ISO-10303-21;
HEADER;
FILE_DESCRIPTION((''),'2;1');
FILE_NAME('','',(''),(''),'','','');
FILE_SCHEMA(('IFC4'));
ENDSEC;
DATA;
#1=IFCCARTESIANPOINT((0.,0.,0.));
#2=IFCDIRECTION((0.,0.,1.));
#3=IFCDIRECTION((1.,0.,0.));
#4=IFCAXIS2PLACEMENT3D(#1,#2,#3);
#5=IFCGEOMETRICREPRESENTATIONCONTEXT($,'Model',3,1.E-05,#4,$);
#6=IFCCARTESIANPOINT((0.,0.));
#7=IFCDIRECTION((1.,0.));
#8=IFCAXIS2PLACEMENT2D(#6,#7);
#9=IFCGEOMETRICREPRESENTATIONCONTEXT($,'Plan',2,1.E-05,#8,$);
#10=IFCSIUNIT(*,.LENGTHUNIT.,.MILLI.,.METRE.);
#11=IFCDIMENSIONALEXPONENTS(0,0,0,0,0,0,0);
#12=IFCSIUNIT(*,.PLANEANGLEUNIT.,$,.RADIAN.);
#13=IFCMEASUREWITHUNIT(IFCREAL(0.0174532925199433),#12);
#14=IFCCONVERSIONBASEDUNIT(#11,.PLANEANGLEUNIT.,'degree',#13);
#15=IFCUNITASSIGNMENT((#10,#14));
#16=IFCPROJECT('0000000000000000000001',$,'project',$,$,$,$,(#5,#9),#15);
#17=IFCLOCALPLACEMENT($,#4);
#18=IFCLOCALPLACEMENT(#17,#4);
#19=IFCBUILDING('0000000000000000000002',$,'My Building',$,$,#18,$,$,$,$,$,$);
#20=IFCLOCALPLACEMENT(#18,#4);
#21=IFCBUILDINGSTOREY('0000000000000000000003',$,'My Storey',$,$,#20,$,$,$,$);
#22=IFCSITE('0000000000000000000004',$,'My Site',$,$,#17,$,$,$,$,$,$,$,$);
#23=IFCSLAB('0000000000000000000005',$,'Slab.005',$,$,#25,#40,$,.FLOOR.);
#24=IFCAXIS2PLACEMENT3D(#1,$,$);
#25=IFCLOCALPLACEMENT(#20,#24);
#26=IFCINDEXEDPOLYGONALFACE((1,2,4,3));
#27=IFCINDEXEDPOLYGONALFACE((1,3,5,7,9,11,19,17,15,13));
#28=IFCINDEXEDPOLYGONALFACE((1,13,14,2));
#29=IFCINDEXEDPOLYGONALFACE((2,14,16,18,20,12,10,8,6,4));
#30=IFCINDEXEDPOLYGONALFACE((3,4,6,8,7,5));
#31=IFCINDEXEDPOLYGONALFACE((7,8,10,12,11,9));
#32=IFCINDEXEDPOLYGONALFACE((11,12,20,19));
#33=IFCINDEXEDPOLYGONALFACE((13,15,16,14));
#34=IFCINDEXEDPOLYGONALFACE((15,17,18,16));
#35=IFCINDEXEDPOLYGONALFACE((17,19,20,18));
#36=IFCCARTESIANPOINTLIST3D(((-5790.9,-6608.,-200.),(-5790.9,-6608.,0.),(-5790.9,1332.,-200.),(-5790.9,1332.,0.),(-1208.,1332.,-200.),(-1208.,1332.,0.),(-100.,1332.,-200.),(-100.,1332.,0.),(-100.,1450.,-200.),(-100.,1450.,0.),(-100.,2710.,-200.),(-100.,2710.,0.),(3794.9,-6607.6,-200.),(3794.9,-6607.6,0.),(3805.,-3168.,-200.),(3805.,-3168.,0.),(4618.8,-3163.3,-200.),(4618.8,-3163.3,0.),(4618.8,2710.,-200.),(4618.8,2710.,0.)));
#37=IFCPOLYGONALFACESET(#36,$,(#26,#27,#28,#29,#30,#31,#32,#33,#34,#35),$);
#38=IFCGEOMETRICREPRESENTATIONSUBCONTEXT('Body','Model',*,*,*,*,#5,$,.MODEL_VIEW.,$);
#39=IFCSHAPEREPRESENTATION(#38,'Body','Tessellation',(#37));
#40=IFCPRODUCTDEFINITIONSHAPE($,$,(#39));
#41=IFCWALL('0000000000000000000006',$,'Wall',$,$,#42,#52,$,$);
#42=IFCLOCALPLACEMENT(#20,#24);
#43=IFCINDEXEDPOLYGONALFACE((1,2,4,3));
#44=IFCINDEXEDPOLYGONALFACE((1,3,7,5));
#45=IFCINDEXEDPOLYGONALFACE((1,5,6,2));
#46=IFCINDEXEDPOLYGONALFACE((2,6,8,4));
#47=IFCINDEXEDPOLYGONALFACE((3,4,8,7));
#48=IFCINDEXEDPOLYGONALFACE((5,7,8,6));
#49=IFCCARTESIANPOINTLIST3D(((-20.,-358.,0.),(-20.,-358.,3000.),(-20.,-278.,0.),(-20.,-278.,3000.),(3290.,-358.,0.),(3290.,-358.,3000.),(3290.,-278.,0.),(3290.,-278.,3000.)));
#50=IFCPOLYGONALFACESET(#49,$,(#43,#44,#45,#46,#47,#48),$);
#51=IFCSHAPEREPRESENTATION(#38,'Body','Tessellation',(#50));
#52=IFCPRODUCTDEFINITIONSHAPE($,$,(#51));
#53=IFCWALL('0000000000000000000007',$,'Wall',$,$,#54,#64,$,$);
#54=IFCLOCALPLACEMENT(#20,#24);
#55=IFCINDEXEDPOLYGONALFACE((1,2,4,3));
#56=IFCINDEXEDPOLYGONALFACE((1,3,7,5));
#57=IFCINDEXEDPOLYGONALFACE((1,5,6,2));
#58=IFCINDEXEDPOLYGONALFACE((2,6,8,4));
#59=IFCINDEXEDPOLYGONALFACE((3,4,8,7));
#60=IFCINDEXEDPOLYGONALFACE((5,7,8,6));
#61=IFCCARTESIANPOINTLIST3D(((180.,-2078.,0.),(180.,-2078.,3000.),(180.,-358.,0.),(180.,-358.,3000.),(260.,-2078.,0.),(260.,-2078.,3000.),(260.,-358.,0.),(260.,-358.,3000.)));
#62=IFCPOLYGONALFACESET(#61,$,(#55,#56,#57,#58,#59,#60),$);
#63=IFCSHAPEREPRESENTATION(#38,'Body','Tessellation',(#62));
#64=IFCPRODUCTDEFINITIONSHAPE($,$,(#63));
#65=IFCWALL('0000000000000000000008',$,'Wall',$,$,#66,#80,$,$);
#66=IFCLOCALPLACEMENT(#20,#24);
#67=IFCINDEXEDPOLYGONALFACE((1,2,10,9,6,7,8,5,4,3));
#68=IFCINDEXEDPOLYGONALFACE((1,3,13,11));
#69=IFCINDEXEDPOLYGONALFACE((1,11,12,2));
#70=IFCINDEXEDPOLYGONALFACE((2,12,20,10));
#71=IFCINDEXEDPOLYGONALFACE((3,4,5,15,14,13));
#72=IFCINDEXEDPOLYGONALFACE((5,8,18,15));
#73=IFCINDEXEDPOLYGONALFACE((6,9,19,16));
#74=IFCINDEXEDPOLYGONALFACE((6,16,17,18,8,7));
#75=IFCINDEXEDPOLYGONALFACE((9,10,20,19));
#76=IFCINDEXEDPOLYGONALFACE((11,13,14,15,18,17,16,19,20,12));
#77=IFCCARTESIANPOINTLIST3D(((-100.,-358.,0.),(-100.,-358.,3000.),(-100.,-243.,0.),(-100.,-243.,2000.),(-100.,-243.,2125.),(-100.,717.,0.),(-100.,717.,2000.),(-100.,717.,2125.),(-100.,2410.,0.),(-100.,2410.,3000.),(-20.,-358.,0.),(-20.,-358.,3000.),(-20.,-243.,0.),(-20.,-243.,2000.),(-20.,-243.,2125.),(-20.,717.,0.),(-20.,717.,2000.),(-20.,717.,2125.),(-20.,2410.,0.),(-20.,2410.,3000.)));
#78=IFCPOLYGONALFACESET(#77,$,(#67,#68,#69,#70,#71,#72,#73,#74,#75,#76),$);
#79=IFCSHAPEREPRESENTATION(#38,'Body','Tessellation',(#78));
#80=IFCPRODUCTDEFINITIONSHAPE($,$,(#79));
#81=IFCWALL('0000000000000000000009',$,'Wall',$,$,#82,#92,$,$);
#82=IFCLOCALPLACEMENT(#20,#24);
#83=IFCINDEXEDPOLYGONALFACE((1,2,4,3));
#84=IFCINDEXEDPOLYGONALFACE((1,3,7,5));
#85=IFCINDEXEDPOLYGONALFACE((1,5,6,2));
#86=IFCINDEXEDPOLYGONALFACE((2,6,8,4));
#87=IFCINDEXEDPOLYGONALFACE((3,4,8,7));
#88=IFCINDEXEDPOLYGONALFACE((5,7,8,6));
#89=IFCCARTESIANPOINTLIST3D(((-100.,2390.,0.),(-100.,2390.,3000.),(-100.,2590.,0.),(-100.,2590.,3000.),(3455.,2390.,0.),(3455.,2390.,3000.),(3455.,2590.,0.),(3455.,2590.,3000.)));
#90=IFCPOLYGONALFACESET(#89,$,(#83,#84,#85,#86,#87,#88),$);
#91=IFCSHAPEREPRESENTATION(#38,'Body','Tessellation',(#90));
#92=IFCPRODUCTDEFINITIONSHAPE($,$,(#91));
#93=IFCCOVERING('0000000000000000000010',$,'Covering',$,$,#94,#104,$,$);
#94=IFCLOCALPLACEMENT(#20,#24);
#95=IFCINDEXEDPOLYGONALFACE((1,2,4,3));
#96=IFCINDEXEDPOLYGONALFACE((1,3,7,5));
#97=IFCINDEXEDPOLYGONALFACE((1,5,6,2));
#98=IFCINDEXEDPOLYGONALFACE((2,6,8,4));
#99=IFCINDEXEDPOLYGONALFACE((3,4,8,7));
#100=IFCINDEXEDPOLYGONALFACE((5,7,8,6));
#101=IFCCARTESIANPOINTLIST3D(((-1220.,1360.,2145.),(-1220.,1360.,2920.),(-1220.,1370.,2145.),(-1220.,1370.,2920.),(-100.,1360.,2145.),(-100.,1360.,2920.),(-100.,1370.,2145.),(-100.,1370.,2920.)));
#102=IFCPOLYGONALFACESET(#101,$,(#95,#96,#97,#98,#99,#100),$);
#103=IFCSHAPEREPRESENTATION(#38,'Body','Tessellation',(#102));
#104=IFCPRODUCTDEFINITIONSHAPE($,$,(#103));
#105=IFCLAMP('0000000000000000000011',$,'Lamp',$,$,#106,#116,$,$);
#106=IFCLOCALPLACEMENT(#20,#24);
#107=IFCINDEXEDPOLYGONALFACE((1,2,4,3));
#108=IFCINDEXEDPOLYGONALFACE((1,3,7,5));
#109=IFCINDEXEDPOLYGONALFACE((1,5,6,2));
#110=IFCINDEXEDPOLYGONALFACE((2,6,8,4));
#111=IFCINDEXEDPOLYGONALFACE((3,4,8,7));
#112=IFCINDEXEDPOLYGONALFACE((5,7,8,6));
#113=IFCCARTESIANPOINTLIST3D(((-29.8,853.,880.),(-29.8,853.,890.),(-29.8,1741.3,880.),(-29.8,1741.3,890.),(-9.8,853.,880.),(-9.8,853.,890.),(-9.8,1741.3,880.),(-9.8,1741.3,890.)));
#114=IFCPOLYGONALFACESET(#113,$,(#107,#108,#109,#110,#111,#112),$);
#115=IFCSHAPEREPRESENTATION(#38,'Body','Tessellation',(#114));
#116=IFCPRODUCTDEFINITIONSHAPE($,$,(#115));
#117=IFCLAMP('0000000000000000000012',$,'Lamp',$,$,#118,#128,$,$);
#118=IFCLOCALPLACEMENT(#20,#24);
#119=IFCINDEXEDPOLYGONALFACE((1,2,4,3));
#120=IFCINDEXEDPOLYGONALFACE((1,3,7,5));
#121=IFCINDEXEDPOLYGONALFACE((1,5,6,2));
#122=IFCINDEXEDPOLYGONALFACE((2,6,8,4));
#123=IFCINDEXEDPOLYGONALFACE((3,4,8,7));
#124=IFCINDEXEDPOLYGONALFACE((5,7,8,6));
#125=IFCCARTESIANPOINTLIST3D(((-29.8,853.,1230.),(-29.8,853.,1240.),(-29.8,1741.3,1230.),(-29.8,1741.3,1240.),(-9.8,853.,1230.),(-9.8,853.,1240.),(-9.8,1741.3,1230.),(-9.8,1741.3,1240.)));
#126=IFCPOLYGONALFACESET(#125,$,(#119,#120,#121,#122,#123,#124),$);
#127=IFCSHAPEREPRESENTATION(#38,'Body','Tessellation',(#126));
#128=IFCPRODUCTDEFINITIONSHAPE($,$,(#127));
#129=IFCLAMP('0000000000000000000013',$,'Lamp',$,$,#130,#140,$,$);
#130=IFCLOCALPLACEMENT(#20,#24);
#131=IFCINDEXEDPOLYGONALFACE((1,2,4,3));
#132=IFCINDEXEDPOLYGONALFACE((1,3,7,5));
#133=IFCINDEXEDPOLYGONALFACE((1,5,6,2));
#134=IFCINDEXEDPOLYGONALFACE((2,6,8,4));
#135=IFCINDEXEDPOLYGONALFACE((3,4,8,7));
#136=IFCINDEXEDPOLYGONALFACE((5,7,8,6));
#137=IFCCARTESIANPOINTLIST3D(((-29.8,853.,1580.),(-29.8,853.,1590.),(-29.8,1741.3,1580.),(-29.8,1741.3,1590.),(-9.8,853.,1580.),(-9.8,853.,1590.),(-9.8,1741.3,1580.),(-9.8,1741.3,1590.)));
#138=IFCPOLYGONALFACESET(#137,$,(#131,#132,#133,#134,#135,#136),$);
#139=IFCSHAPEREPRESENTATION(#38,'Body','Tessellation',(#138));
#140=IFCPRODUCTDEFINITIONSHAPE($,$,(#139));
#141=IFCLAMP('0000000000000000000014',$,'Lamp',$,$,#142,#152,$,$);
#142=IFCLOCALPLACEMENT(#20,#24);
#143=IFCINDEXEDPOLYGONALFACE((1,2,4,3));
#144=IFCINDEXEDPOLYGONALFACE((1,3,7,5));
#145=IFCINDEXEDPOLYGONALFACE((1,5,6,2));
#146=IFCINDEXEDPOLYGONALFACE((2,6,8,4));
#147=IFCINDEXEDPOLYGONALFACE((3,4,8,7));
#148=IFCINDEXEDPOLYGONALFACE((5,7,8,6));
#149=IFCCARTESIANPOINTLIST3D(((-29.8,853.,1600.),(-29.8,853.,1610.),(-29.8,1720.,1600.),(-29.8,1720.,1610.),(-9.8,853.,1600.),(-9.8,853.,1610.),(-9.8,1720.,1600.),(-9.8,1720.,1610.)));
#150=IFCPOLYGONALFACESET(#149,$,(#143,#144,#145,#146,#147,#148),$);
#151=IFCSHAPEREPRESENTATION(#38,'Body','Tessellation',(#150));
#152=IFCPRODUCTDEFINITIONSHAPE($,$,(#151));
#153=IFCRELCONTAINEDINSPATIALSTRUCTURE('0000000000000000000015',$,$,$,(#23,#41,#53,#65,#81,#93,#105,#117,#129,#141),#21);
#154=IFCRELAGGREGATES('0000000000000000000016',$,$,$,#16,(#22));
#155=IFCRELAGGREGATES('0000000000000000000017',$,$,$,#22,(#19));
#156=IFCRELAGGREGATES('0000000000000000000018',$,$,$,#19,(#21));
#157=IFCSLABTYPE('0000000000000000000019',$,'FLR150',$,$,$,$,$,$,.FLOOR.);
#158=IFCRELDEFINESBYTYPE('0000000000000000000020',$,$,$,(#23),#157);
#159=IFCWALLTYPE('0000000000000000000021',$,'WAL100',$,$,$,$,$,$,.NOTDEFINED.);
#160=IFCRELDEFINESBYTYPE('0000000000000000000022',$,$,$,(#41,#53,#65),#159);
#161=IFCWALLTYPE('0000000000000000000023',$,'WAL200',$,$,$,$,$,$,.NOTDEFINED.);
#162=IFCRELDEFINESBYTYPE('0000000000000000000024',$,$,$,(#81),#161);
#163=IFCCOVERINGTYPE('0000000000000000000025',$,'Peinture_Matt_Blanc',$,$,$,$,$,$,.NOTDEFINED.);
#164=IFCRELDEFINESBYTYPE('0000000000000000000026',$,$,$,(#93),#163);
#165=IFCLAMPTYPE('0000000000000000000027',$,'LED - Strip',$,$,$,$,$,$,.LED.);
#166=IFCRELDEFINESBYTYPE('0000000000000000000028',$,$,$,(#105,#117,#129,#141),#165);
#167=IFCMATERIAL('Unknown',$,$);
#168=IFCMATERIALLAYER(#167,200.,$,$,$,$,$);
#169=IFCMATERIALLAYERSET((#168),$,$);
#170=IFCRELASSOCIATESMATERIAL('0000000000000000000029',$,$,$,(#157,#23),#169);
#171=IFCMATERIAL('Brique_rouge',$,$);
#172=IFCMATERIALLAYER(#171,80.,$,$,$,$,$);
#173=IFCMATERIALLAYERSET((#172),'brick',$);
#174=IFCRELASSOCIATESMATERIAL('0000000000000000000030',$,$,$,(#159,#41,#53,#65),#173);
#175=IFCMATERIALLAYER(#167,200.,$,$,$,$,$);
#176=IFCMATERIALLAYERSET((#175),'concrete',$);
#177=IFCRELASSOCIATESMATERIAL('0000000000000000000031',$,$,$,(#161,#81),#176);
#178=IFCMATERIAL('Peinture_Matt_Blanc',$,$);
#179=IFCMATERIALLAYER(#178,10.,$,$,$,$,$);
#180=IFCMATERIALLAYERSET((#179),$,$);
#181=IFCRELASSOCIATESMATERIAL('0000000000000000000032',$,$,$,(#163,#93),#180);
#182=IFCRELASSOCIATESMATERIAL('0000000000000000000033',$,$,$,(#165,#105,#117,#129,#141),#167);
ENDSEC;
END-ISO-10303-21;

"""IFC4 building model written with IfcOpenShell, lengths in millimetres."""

from ifc_helpers import new_model, entity, si_unit, converted_unit, frame, origin_with_axes, origin_2d_with_axis, place, context, subcontext, project, spatial, line, indexed_curve, outline, extrude, clip, halfspace, source, transform, mapped, material, layer, layer_set, layer_usage, material_profile, profile_set, profile_usage, type_object, element, save


model = new_model("IFC4")

# Units and contexts
model_context = context("Model", 3, precision=1e-05, world=origin_with_axes())
plan_context = context("Plan", 2, precision=1e-05, world=origin_2d_with_axis())
body_context = subcontext(model_context, "Body", "Model", "MODEL_VIEW")
ifc_project = project(units=[si_unit("LENGTHUNIT", "METRE", prefix="MILLI"), converted_unit("PLANEANGLEUNIT", "degree", entity("IfcReal", 0.0174532925199433), si_unit("PLANEANGLEUNIT", "RADIAN"), dimensions=[0, 0, 0, 0, 0, 0, 0])], contexts=[model_context, plan_context])

# Site, building, storey
site_placement = place(None, origin_with_axes())
site = spatial("IfcSite", under=ifc_project, at=site_placement, Name="My Site")
building_placement = place(site_placement, origin_with_axes())
building = spatial("IfcBuilding", under=site, at=building_placement, Name="My Building")
storey_placement = place(building_placement, origin_with_axes())
storey = spatial("IfcBuildingStorey", under=building, at=storey_placement, Name="My Storey")

# Slab
ifc_material_1 = material(Name="Unknown")
ifc_layer_1 = layer(ifc_material_1, 200.0)
ifc_layer_set_1 = layer_set([ifc_layer_1])
ifc_layer_usage_1 = layer_usage(ifc_layer_set_1, "AXIS3", "POSITIVE", 0.0)
slab_type = type_object("IfcSlabType", Name="FLR150", PredefinedType="FLOOR", material=ifc_layer_set_1)
slab_placement = place(storey_placement, frame((0.0, 0.0, -200.0), z_axis=(0.0, 0.0, 1.0), x_axis=(1.0, 0.0, 0.0)))
element("IfcSlab", 1, at=slab_placement, inside=storey, type_object=slab_type, material=ifc_layer_usage_1, Name="Slab.005", PredefinedType="FLOOR", context=body_context, shape_type="SolidModel", body=[
    extrude(outline(indexed_curve([(4618.8, 2710.0), (4618.8, -3163.3), (3805.0, -3168.0), (3794.9, -6607.6), (-5790.9, -6608.0), (-5790.9, 1332.0), (-1208.0, 1332.0), (-100.0, 1332.0), (-100.0, 1450.0), (-100.0, 2710.0), (4618.8, 2710.0)])), None, (0.0, 0.0, 1.0), 200.0),
])

# Wall
ifc_material_2 = material(Name="Brique_rouge")
ifc_layer_2 = layer(ifc_material_2, 80.0)
ifc_layer_set_2 = layer_set([ifc_layer_2], Name="brick")
ifc_layer_usage_2 = layer_usage(ifc_layer_set_2, "AXIS2", "POSITIVE", 0.0)
wall_type_1 = type_object("IfcWallType", Name="WAL100", PredefinedType="NOTDEFINED", material=ifc_layer_set_2)
wall_1_placement = place(storey_placement, frame((-20.0, -358.0, 0.0), z_axis=(0.0, 0.0, 1.0), x_axis=(1.0, 0.0, 0.0)))
element("IfcWall", 2, at=wall_1_placement, inside=storey, type_object=wall_type_1, material=ifc_layer_usage_2, Name="Wall", context=body_context, shape_type="SweptSolid", body=[
    extrude(outline(indexed_curve([(0.0, 0.0), (0.0, 80.0), (3310.0, 80.0), (3310.0, 0.0), (0.0, 0.0)], self_intersect=False)), origin_with_axes(), (0.0, 0.0, 1.0), 3000.0),
])

# Wall
ifc_layer_usage_3 = layer_usage(ifc_layer_set_2, "AXIS2", "POSITIVE", 0.0)
wall_2_placement = place(storey_placement, frame((180.0, -358.0, 0.0), z_axis=(0.0, 0.0, 1.0), x_axis=(-0.000001, -1.0, 0.0)))
element("IfcWall", 3, at=wall_2_placement, inside=storey, type_object=wall_type_1, material=ifc_layer_usage_3, Name="Wall", context=body_context, shape_type="SweptSolid", body=[
    extrude(outline(indexed_curve([(0.0, 0.0), (0.0, 80.0), (1720.0, 80.0), (1720.0, 0.0), (0.0, 0.0)], self_intersect=False)), origin_with_axes(), (0.0, 0.0, 1.0), 3000.0),
])

# Wall, openings
ifc_layer_usage_4 = layer_usage(ifc_layer_set_2, "AXIS2", "POSITIVE", 0.0)
wall_3_placement = place(storey_placement, frame((-20.0, -358.0, 0.0), z_axis=(0.0, 0.0, 1.0), x_axis=(0.000001, 1.0, 0.0)))
wall_3 = element("IfcWall", 4, at=wall_3_placement, inside=storey, type_object=wall_type_1, material=ifc_layer_usage_4, Name="Wall", context=body_context, shape_type="SweptSolid", body=[
    extrude(outline(indexed_curve([(0.0, 0.0), (0.0, 80.0), (2768.0, 80.0), (2768.0, 0.0), (0.0, 0.0)], self_intersect=False)), origin_with_axes(), (0.0, 0.0, 1.0), 3000.0),
])
shared_shape_1 = source(origin_with_axes(), body_context, "Body", "SweptSolid", [
    extrude(outline(indexed_curve([(0.0, 0.0), (960.0, 0.0), (960.0, 2000.0), (0.0, 2000.0)], segments=[line(1, 2, 3, 4, 1)])), frame((0.0, -600.0, 0.0), z_axis=(0.0, -1.0, 0.0), x_axis=(1.0, 0.0, 0.0)), (0.0, 0.0, -1.0), 1200.0),
])
opening_1_placement = place(wall_3_placement, frame((115.0, 0.0, 0.0), z_axis=(0.0, 0.0, 1.0), x_axis=(1.0, 0.0, 0.0)))
element("IfcOpeningElement", 5, at=opening_1_placement, cuts=wall_3, PredefinedType="OPENING", context=body_context, shape_type="MappedRepresentation", body=[
    mapped(shared_shape_1, transform((0.0, 0.0, 0.0), x_axis=(1.0, 0.0, 0.0), y_axis=(0.0, 1.0, 0.0), z_axis=(0.0, 0.0, 1.0), scale=1.0)),
])
shared_shape_2 = source(origin_with_axes(), body_context, "Body", "SweptSolid", [
    extrude(outline(indexed_curve([(0.0, 0.0), (960.0, 0.0), (960.0, 2125.0), (0.0, 2125.0)], segments=[line(4, 1), line(1, 2), line(2, 3), line(3, 4)], self_intersect=False)), frame((0.0, -600.0, 0.0), z_axis=(0.0, -1.0, 0.0), x_axis=(1.0, 0.0, 0.0)), (0.0, 0.0, -1.0), 1200.0),
])
opening_2_placement = place(wall_3_placement, frame((115.0, 0.0, 0.0), z_axis=(0.0, 0.0, 1.0), x_axis=(1.0, 0.0, 0.0)))
element("IfcOpeningElement", 6, at=opening_2_placement, cuts=wall_3, PredefinedType="OPENING", context=body_context, shape_type="MappedRepresentation", body=[
    mapped(shared_shape_2, transform((0.0, 0.0, 0.0), x_axis=(1.0, 0.0, 0.0), y_axis=(0.0, 1.0, 0.0), z_axis=(0.0, 0.0, 1.0), scale=1.0)),
])

# Wall
ifc_layer_3 = layer(ifc_material_1, 200.0)
ifc_layer_set_3 = layer_set([ifc_layer_3], Name="concrete")
ifc_layer_usage_5 = layer_usage(ifc_layer_set_3, "AXIS2", "POSITIVE", 0.0)
wall_type_2 = type_object("IfcWallType", Name="WAL200", PredefinedType="NOTDEFINED", material=ifc_layer_set_3)
wall_4_placement = place(storey_placement, frame((-100.0, 2390.0, 0.0), z_axis=(0.0, 0.0, 1.0), x_axis=(1.0, -0.000001, 0.0)))
element("IfcWall", 7, at=wall_4_placement, inside=storey, type_object=wall_type_2, material=ifc_layer_usage_5, Name="Wall", context=body_context, shape_type="SweptSolid", body=[
    extrude(outline(indexed_curve([(0.0, 0.0), (0.0, 200.0), (3555.0, 200.0), (3555.0, 0.0), (0.0, 0.0)], self_intersect=False)), origin_with_axes(), (0.0, 0.0, 1.0), 3000.0),
])

# Shared definitions
ifc_material_3 = material(Name="Peinture_Matt_Blanc")
ifc_layer_4 = layer(ifc_material_3, 10.0)
ifc_layer_set_4 = layer_set([ifc_layer_4])
covering_type_1 = type_object("IfcCoveringType", Name="Peinture_Matt_Blanc", PredefinedType="NOTDEFINED", material=ifc_layer_set_4)

# Covering
ifc_layer_usage_6 = layer_usage(ifc_layer_set_4, "AXIS2", "POSITIVE", 0.0)
covering_1_placement = place(storey_placement, frame((-100.0, 1370.0, 2145.0), z_axis=(0.0, 0.0, 1.0), x_axis=(-1.0, 0.000001, 0.0)))
element("IfcCovering", 8, at=covering_1_placement, inside=storey, type_object=covering_type_1, material=ifc_layer_usage_6, Name="Covering", context=body_context, shape_type="Clipping", body=[
    clip(clip(extrude(outline(indexed_curve([(0.0, 0.0), (0.0, 10.0), (1120.0, 10.0), (1120.0, 0.0), (0.0, 0.0)], self_intersect=False)), origin_with_axes(), (0.0, 0.0, 1.0), 2920.0), halfspace(frame((0.0, 0.0, 775.0), z_axis=(0.0, 0.0, 1.0), x_axis=(-1.0, 0.0, 0.0)), False)), halfspace(frame((0.0, 0.0, 775.0), z_axis=(0.0, 0.0, 1.0), x_axis=(-1.0, 0.0, 0.0)), False)),
])

# Lamps
ifc_material_profile = material_profile(ifc_material_1, outline(indexed_curve([(-10.0, 10.0), (-10.0, 0.0), (10.0, 0.0), (10.0, 10.0)], segments=[line(4, 1), line(1, 2), line(2, 3), line(3, 4)], self_intersect=False)))
ifc_profile_set = profile_set([ifc_material_profile])
ifc_profile_usage_1 = profile_usage(ifc_profile_set, cardinal=5)
lamp_type = type_object("IfcLampType", Name="LED - Strip", PredefinedType="LED", material=ifc_profile_set)
lamp_1_placement = place(storey_placement, frame((-19.8, 1741.3, 890.0), z_axis=(0.0, -1.0, 0.0), x_axis=(-1.0, 0.0, 0.0)))
element("IfcLamp", 9, at=lamp_1_placement, inside=storey, type_object=lamp_type, material=ifc_profile_usage_1, Name="Lamp", context=body_context, shape_type="SweptSolid", body=[
    extrude(outline(indexed_curve([(-10.0, 10.0), (-10.0, 0.0), (10.0, 0.0), (10.0, 10.0)], segments=[line(4, 1), line(1, 2), line(2, 3), line(3, 4)], self_intersect=False)), origin_with_axes(), (0.0, 0.0, 1.0), 888.3),
])
ifc_profile_usage_2 = profile_usage(ifc_profile_set, cardinal=5)
lamp_2_placement = place(storey_placement, frame((-19.8, 1741.3, 1240.0), z_axis=(0.0, -1.0, 0.0), x_axis=(-1.0, 0.0, 0.0)))
element("IfcLamp", 10, at=lamp_2_placement, inside=storey, type_object=lamp_type, material=ifc_profile_usage_2, Name="Lamp", context=body_context, shape_type="SweptSolid", body=[
    extrude(outline(indexed_curve([(-10.0, 10.0), (-10.0, 0.0), (10.0, 0.0), (10.0, 10.0)], segments=[line(4, 1), line(1, 2), line(2, 3), line(3, 4)], self_intersect=False)), origin_with_axes(), (0.0, 0.0, 1.0), 888.3),
])
ifc_profile_usage_3 = profile_usage(ifc_profile_set, cardinal=5)
lamp_3_placement = place(storey_placement, frame((-19.8, 1741.3, 1590.0), z_axis=(0.0, -1.0, 0.0), x_axis=(-1.0, 0.0, 0.0)))
element("IfcLamp", 11, at=lamp_3_placement, inside=storey, type_object=lamp_type, material=ifc_profile_usage_3, Name="Lamp", context=body_context, shape_type="SweptSolid", body=[
    extrude(outline(indexed_curve([(-10.0, 10.0), (-10.0, 0.0), (10.0, 0.0), (10.0, 10.0)], segments=[line(4, 1), line(1, 2), line(2, 3), line(3, 4)], self_intersect=False)), origin_with_axes(), (0.0, 0.0, 1.0), 888.3),
])
ifc_profile_usage_4 = profile_usage(ifc_profile_set, cardinal=5)
lamp_4_placement = place(storey_placement, frame((-19.8, 1720.0, 1610.0), z_axis=(0.0, -1.0, 0.0), x_axis=(-1.0, 0.0, 0.0)))
element("IfcLamp", 12, at=lamp_4_placement, inside=storey, type_object=lamp_type, material=ifc_profile_usage_4, Name="Lamp", context=body_context, shape_type="SweptSolid", body=[
    extrude(outline(indexed_curve([(-10.0, 10.0), (-10.0, 0.0), (10.0, 0.0), (10.0, 10.0)], segments=[line(4, 1), line(1, 2), line(2, 3), line(3, 4)], self_intersect=False)), origin_with_axes(), (0.0, 0.0, 1.0), 867.0),
])

save(model, "model.ifc")
